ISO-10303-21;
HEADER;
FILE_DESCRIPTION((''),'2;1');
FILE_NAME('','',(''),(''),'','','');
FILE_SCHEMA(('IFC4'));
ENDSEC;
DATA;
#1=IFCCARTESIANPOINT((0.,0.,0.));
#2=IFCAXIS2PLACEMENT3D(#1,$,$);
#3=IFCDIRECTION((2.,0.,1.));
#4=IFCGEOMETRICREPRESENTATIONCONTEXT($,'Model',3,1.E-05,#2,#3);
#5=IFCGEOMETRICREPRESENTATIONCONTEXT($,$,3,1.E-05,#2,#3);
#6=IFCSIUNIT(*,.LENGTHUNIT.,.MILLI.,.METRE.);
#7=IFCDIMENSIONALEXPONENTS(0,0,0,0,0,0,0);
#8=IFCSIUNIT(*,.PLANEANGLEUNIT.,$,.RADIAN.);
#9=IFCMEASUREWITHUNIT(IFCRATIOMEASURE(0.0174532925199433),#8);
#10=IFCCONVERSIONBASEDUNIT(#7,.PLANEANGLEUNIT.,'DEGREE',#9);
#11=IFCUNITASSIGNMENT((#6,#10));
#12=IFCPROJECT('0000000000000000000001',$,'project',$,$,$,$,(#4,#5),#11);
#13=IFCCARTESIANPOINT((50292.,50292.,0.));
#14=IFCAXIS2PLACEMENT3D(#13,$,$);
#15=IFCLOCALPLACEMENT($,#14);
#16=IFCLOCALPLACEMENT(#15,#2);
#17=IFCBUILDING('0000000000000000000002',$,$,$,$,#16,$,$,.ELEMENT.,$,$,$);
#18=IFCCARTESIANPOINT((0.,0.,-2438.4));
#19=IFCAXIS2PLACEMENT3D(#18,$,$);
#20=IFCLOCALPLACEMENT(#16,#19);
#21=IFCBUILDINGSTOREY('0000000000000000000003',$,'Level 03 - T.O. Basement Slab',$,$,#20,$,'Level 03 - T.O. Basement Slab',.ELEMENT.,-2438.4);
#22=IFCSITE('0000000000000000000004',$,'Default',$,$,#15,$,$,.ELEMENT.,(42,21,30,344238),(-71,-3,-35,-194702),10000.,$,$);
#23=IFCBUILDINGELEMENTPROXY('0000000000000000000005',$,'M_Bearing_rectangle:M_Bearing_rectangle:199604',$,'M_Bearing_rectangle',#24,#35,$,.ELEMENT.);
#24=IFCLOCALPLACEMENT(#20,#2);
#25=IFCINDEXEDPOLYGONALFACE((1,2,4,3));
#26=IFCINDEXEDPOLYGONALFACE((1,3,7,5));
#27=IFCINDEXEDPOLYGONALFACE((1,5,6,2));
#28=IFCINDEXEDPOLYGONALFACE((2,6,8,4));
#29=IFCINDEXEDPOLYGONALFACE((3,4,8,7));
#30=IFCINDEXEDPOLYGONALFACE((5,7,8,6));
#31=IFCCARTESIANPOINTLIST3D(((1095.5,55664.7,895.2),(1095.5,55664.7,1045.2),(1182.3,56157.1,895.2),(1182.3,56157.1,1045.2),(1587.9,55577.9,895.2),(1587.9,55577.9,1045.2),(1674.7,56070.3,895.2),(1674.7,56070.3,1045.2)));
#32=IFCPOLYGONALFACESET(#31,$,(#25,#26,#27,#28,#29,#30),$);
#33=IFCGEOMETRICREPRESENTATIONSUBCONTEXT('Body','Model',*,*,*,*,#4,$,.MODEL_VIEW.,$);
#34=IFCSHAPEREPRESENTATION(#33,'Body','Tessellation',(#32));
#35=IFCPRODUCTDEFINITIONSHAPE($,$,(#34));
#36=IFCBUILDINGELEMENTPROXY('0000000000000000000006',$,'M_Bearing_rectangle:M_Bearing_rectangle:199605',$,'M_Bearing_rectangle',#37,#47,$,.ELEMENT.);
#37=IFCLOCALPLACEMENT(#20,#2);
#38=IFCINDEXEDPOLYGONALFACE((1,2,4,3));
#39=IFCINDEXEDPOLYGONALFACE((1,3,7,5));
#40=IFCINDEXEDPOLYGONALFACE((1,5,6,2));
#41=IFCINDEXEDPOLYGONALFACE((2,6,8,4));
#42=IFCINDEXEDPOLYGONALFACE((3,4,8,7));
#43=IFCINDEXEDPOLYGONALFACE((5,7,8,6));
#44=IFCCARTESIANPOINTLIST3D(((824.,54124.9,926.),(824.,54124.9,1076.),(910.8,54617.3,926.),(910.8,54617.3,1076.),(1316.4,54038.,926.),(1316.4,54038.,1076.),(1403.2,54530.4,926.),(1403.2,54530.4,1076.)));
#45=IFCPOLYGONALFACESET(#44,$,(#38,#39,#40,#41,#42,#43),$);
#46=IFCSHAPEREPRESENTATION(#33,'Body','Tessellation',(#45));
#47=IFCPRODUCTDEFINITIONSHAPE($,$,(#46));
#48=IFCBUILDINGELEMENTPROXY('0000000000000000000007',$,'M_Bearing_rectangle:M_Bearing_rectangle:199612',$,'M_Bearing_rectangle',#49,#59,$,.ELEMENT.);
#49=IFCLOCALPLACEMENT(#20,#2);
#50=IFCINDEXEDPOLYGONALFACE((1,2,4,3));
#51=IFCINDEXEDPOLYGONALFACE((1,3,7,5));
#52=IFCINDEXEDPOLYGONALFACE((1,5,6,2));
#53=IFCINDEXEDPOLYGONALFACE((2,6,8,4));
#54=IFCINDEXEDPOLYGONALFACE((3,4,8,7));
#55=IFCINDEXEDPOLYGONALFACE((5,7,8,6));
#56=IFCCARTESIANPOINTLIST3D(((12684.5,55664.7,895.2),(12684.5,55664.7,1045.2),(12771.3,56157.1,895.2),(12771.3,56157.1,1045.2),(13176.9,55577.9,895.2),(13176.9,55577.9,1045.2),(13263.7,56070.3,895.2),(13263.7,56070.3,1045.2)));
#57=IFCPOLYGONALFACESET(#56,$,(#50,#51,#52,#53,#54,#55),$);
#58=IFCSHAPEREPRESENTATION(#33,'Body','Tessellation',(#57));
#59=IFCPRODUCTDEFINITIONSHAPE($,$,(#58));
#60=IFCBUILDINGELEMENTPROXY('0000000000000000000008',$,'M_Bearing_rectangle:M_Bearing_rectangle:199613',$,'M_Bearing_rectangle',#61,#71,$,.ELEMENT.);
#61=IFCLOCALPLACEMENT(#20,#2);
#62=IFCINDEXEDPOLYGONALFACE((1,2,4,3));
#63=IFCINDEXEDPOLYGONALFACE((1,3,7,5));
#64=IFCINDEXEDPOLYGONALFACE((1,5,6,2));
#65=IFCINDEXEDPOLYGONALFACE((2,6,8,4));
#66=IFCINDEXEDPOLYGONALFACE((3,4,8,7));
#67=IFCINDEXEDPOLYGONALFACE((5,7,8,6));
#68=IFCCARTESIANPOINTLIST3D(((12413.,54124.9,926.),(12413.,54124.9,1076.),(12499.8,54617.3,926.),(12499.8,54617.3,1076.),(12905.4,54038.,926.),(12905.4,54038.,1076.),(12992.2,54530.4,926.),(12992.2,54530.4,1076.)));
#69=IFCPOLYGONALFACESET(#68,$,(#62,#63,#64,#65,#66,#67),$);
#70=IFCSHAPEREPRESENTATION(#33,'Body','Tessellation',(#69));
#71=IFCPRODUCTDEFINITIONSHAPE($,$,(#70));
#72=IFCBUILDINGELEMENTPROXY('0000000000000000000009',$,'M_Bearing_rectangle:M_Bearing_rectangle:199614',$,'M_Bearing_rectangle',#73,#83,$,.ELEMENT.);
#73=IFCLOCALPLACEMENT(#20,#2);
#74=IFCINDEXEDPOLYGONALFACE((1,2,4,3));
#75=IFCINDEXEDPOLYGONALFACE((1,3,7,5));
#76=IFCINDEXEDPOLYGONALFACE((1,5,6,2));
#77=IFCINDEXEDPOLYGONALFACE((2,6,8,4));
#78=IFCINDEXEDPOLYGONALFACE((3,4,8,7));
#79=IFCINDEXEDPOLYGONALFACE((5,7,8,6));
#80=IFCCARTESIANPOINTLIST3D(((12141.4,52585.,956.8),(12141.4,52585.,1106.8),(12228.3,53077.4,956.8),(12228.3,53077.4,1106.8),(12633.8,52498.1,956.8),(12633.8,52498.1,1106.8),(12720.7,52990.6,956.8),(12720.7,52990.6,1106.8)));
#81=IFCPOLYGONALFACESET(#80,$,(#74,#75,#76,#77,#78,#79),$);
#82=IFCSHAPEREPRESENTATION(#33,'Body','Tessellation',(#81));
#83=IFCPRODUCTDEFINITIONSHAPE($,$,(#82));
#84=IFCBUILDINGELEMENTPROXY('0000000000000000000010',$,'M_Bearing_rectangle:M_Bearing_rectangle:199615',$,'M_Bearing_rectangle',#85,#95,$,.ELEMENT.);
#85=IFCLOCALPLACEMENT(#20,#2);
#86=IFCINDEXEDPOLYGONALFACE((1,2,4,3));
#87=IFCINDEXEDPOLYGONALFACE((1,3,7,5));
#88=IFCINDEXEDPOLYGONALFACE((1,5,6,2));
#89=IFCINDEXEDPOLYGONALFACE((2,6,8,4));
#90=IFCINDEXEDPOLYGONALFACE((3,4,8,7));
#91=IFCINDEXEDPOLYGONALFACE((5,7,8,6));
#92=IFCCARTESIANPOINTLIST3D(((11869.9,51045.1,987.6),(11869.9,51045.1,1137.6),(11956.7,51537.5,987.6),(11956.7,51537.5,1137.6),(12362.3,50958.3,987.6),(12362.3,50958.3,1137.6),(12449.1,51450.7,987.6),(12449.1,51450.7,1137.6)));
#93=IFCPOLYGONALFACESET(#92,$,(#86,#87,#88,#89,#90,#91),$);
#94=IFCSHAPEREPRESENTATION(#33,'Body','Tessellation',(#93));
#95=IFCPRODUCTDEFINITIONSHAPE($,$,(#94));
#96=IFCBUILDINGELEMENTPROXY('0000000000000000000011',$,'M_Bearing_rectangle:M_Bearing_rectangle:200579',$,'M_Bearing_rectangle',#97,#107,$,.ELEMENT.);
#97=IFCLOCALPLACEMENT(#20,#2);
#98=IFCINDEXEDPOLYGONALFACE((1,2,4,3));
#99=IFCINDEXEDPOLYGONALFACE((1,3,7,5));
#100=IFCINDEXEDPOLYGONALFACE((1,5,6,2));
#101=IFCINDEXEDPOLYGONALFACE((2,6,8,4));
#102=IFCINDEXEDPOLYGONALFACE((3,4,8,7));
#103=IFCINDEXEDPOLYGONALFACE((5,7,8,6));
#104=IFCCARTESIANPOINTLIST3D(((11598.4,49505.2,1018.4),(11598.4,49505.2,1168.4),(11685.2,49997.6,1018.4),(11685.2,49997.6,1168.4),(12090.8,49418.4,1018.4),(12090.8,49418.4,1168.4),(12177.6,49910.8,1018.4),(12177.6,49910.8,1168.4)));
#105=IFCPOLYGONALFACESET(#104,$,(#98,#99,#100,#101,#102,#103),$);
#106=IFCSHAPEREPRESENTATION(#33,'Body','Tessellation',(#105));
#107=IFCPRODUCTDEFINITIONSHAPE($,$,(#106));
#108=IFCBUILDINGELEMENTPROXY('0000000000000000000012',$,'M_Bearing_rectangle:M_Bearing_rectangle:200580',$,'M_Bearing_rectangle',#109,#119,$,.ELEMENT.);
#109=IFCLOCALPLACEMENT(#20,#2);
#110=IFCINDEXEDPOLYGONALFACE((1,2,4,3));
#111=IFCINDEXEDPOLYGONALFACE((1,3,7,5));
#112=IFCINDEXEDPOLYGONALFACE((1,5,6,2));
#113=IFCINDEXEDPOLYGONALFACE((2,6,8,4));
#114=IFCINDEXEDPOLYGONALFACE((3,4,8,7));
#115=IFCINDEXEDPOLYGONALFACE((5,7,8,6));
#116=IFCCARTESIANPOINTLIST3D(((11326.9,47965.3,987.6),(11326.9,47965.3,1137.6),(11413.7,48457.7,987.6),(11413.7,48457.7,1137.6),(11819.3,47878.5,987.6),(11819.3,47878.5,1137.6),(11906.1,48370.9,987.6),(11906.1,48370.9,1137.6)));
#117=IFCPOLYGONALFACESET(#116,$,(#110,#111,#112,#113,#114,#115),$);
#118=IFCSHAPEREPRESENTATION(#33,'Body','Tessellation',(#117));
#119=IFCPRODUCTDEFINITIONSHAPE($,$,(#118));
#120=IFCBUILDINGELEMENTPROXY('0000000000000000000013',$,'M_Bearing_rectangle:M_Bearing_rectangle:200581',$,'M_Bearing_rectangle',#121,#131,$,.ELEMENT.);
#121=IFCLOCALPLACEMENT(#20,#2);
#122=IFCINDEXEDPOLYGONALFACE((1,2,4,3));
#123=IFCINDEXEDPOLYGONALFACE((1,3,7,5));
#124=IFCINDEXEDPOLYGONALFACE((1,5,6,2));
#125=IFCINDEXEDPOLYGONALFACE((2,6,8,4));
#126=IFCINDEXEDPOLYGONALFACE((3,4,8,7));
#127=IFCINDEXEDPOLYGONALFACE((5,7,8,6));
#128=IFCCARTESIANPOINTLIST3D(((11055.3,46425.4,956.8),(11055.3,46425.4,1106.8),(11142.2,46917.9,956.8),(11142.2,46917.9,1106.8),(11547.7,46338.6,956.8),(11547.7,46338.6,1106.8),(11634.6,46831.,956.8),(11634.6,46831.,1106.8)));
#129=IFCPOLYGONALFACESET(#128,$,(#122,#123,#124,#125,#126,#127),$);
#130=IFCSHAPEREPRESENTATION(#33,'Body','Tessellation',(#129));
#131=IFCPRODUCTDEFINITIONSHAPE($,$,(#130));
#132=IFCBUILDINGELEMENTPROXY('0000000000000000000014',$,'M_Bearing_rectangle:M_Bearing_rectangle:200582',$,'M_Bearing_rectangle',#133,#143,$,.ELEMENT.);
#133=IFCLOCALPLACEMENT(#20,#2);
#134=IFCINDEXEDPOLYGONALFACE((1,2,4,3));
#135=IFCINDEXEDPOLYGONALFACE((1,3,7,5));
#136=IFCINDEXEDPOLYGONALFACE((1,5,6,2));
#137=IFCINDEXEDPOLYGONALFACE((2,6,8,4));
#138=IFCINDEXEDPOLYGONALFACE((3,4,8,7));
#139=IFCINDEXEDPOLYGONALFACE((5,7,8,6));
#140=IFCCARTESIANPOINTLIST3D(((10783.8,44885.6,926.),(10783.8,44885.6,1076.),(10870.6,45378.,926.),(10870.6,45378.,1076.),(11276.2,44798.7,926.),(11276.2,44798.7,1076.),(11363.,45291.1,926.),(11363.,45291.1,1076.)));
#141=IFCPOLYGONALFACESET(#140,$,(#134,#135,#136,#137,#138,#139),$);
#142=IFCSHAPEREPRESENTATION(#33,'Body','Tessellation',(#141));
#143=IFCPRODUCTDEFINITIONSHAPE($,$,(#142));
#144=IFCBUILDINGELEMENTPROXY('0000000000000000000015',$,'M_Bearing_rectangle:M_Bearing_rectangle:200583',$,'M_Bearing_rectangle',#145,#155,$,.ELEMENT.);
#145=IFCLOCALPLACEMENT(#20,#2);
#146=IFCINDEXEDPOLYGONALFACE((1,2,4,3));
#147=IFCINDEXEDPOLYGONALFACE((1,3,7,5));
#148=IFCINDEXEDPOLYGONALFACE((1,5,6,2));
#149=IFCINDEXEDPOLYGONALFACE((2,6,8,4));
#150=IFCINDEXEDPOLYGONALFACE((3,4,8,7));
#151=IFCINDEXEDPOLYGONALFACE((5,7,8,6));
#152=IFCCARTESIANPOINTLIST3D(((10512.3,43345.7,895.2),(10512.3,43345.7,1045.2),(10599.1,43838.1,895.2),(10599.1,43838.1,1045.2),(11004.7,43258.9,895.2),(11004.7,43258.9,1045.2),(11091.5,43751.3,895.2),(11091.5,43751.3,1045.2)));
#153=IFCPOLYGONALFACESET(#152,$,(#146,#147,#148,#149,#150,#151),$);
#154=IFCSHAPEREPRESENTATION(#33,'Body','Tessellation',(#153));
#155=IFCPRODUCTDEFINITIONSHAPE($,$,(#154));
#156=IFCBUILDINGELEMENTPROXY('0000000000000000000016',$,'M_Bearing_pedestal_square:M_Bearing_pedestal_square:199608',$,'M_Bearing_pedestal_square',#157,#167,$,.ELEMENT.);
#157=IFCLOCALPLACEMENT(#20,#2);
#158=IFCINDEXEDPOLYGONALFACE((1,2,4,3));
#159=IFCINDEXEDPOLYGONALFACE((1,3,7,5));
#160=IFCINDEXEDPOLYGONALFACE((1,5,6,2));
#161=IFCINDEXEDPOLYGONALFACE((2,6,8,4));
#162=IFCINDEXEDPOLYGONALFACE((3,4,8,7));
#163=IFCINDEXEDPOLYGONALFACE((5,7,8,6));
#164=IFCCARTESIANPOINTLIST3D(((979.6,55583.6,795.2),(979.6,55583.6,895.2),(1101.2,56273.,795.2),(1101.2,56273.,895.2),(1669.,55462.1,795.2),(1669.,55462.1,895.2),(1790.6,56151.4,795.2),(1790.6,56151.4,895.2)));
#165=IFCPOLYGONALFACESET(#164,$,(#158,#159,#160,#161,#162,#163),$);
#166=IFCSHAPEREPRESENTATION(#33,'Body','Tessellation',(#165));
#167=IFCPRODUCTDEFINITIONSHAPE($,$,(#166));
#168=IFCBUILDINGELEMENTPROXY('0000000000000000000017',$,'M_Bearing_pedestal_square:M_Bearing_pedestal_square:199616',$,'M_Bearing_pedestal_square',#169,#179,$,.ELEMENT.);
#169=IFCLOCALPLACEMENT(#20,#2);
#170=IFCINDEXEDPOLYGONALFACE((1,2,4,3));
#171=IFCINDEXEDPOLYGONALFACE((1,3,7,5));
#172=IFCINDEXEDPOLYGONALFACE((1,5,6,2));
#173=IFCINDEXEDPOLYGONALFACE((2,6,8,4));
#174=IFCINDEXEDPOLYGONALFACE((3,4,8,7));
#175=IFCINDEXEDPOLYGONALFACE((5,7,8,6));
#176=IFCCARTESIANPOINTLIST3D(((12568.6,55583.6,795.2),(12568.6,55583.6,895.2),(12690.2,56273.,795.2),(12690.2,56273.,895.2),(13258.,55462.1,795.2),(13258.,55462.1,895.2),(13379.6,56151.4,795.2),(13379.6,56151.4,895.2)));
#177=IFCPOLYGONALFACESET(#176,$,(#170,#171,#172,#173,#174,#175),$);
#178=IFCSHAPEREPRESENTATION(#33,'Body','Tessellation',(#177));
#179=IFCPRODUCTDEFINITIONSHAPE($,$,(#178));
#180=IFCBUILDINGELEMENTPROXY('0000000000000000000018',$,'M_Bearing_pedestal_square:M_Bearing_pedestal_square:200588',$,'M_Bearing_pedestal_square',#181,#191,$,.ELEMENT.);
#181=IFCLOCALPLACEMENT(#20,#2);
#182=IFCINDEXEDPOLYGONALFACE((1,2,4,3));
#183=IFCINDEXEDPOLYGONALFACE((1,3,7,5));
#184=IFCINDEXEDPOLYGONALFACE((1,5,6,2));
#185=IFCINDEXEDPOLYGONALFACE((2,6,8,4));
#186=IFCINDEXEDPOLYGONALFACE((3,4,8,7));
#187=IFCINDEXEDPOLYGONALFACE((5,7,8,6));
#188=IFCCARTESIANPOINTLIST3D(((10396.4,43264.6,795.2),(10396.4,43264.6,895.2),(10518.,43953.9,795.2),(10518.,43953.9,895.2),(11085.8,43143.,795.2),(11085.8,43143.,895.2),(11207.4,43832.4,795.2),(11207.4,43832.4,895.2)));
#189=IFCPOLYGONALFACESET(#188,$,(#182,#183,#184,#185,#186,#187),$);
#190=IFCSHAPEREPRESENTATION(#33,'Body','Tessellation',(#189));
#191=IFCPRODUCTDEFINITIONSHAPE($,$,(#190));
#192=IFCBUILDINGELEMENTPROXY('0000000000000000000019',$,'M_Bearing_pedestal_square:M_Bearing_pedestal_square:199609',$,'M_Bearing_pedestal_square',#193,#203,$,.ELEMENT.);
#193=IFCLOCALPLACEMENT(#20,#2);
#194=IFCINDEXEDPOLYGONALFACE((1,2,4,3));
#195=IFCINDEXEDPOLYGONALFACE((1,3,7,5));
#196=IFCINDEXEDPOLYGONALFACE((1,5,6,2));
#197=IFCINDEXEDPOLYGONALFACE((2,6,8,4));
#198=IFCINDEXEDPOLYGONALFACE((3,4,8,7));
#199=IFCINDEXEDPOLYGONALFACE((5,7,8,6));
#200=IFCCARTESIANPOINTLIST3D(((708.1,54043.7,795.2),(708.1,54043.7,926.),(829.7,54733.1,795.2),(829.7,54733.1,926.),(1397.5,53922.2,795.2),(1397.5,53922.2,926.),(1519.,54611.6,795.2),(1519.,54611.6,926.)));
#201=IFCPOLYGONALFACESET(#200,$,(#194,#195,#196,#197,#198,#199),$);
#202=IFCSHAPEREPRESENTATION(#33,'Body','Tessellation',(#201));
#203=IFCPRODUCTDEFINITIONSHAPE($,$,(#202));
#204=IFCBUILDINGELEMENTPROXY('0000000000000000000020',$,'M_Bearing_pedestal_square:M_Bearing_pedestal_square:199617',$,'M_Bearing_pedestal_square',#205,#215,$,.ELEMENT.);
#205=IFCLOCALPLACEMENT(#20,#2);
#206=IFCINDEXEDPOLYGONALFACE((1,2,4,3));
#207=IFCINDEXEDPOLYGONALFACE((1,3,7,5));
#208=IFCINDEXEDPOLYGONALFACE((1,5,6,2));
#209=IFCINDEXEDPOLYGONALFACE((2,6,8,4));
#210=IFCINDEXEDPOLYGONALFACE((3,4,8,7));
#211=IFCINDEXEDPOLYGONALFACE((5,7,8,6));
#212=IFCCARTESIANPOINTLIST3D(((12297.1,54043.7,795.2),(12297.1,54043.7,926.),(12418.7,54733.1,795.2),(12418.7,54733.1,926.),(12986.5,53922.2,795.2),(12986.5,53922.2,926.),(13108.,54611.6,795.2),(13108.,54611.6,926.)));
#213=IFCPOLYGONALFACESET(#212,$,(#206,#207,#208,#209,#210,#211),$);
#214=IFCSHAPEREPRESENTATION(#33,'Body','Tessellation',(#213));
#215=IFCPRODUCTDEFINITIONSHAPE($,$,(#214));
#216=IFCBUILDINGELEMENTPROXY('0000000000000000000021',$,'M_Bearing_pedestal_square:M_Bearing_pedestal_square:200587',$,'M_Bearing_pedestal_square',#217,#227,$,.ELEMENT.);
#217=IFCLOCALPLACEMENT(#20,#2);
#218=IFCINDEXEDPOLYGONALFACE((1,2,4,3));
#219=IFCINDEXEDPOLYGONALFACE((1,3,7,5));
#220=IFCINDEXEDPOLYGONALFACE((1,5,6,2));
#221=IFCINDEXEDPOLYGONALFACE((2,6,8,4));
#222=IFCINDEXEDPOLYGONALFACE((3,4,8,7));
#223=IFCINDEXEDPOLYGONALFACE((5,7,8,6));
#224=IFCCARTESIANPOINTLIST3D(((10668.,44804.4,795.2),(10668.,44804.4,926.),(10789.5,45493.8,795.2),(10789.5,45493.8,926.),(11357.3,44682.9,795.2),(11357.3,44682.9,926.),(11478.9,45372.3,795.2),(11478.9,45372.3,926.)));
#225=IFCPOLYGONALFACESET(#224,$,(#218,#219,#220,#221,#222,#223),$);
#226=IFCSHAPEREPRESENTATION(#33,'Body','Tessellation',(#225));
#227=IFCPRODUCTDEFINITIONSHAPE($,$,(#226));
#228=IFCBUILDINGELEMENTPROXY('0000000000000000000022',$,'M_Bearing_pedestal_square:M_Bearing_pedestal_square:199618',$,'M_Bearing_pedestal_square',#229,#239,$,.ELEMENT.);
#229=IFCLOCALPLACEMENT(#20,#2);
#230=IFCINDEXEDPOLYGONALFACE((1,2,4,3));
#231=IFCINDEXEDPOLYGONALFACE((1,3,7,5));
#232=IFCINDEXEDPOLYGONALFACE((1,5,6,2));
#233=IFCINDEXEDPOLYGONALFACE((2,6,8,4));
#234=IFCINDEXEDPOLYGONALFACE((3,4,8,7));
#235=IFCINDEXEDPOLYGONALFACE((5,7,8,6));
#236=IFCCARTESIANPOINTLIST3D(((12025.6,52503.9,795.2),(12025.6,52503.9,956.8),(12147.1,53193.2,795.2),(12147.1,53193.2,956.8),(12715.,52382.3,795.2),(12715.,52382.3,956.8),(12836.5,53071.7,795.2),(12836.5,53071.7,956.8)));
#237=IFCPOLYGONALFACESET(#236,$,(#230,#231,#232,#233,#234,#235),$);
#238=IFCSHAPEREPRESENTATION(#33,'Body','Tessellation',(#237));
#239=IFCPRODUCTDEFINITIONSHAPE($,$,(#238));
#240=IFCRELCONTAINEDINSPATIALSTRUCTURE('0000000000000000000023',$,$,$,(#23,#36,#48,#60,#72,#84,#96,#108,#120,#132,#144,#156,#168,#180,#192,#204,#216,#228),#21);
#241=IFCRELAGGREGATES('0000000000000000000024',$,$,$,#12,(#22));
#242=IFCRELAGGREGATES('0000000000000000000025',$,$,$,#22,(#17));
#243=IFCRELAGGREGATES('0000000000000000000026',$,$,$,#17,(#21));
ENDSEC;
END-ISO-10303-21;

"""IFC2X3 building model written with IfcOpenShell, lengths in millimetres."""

from ifc_helpers import new_model, entity, si_unit, converted_unit, direction, frame, origin, origin_2d_with_axis, place, context, subcontext, project, spatial, rectangle, extrude, source, transform, mapped, element, save


model = new_model("IFC2X3")

# Units and contexts
model_context = context("Model", 3, precision=1e-05, world=origin(), true_north=direction((2.0, 0.0, 1.0)))
context_of_model = context(None, 3, precision=1e-05, world=origin(), true_north=direction((2.0, 0.0, 1.0)))
body_context = subcontext(model_context, "Body", "Model", "MODEL_VIEW")
ifc_project = project(units=[si_unit("LENGTHUNIT", "METRE", prefix="MILLI"), converted_unit("PLANEANGLEUNIT", "DEGREE", entity("IfcRatioMeasure", 0.0174532925199433), si_unit("PLANEANGLEUNIT", "RADIAN"), dimensions=[0, 0, 0, 0, 0, 0, 0])], contexts=[model_context, context_of_model])

# Site, building, storey
site_placement = place(None, frame((50292.0, 50292.0, 0.0)))
site = spatial("IfcSite", under=ifc_project, at=site_placement, Name="Default", CompositionType="ELEMENT", RefLatitude=(42, 21, 30, 344238), RefLongitude=(-71, -3, -35, -194702), RefElevation=10000.0)
building_placement = place(site_placement, origin())
building = spatial("IfcBuilding", under=site, at=building_placement, CompositionType="ELEMENT")
storey_placement = place(building_placement, frame((0.0, 0.0, -2438.4)))
storey = spatial("IfcBuildingStorey", under=building, at=storey_placement, Name="Level 03 - T.O. Basement Slab", LongName="Level 03 - T.O. Basement Slab", CompositionType="ELEMENT", Elevation=-2438.4)

# Building element proxies
shared_shape_1 = source(origin(), body_context, "Body", "SweptSolid", [
    extrude(rectangle(XDim=500.0, YDim=500.0, at=origin_2d_with_axis()), frame((0.0, 0.0, -150.0), z_axis=(0.0, 0.0, 1.0), x_axis=(-1.0, 0.0, 0.0)), (0.0, 0.0, 1.0), 150.0),
])
for number, where, z_axis, x_axis, name in (
    (1, (1385.1, 55867.5, 1045.2), (0.0, 0.0, 1.0), (0.173648, 0.984808, 0.0), "M_Bearing_rectangle:M_Bearing_rectangle:199604"),
    (2, (1113.6, 54327.6, 1076.0), (0.0, 0.0, 1.0), (0.173648, 0.984808, 0.0), "M_Bearing_rectangle:M_Bearing_rectangle:199605"),
    (3, (12974.1, 55867.5, 1045.2), (0.0, 0.0, 1.0), (0.173648, 0.984808, 0.0), "M_Bearing_rectangle:M_Bearing_rectangle:199612"),
    (4, (12702.6, 54327.6, 1076.0), (0.0, 0.0, 1.0), (0.173648, 0.984808, 0.0), "M_Bearing_rectangle:M_Bearing_rectangle:199613"),
    (5, (12431.0, 52787.8, 1106.8), (0.0, 0.0, 1.0), (0.173648, 0.984808, 0.0), "M_Bearing_rectangle:M_Bearing_rectangle:199614"),
    (6, (12159.5, 51247.9, 1137.6), (0.0, 0.0, 1.0), (0.173648, 0.984808, 0.0), "M_Bearing_rectangle:M_Bearing_rectangle:199615"),
    (7, (11888.0, 49708.0, 1168.4), (0.0, 0.0, 1.0), (0.173648, 0.984808, 0.0), "M_Bearing_rectangle:M_Bearing_rectangle:200579"),
    (8, (11616.5, 48168.1, 1137.6), (0.0, 0.0, 1.0), (0.173648, 0.984808, 0.0), "M_Bearing_rectangle:M_Bearing_rectangle:200580"),
    (9, (11345.0, 46628.2, 1106.8), (0.0, 0.0, 1.0), (0.173648, 0.984808, 0.0), "M_Bearing_rectangle:M_Bearing_rectangle:200581"),
    (10, (11073.4, 45088.4, 1076.0), (0.0, 0.0, 1.0), (0.173648, 0.984808, 0.0), "M_Bearing_rectangle:M_Bearing_rectangle:200582"),
    (11, (10801.9, 43548.5, 1045.2), (0.0, 0.0, 1.0), (0.173648, 0.984808, 0.0), "M_Bearing_rectangle:M_Bearing_rectangle:200583"),
):
    element("IfcBuildingElementProxy", number, at=place(storey_placement, frame(where, z_axis=z_axis, x_axis=x_axis)), inside=storey, Name=name, ObjectType="M_Bearing_rectangle", CompositionType="ELEMENT", context=body_context, shape_type="MappedRepresentation", body=[
        mapped(shared_shape_1, transform((0.0, 0.0, 0.0), scale=1.0)),
    ])
shared_shape_2 = source(origin(), body_context, "Body", "SweptSolid", [
    extrude(rectangle(XDim=700.0, YDim=700.0, at=origin_2d_with_axis()), frame((0.0, 0.0, -100.0)), (0.0, 0.0, 1.0), 100.0),
])
for number, where, z_axis, x_axis, name in (
    (12, (1385.1, 55867.5, 895.2), (0.0, 0.0, 1.0), (0.173648, 0.984808, 0.0), "M_Bearing_pedestal_square:M_Bearing_pedestal_square:199608"),
    (13, (12974.1, 55867.5, 895.2), (0.0, 0.0, 1.0), (0.173648, 0.984808, 0.0), "M_Bearing_pedestal_square:M_Bearing_pedestal_square:199616"),
    (14, (10801.9, 43548.5, 895.2), (0.0, 0.0, 1.0), (0.173648, 0.984808, 0.0), "M_Bearing_pedestal_square:M_Bearing_pedestal_square:200588"),
):
    element("IfcBuildingElementProxy", number, at=place(storey_placement, frame(where, z_axis=z_axis, x_axis=x_axis)), inside=storey, Name=name, ObjectType="M_Bearing_pedestal_square", CompositionType="ELEMENT", context=body_context, shape_type="MappedRepresentation", body=[
        mapped(shared_shape_2, transform((0.0, 0.0, 0.0), scale=1.0)),
    ])
shared_shape_3 = source(origin(), body_context, "Body", "SweptSolid", [
    extrude(rectangle(XDim=700.0, YDim=700.0, at=origin_2d_with_axis()), frame((0.0, 0.0, -130.8)), (0.0, 0.0, 1.0), 130.8),
])
for number, where, z_axis, x_axis, name in (
    (15, (1113.6, 54327.6, 926.0), (0.0, 0.0, 1.0), (0.173648, 0.984808, 0.0), "M_Bearing_pedestal_square:M_Bearing_pedestal_square:199609"),
    (16, (12702.6, 54327.6, 926.0), (0.0, 0.0, 1.0), (0.173648, 0.984808, 0.0), "M_Bearing_pedestal_square:M_Bearing_pedestal_square:199617"),
    (17, (11073.4, 45088.4, 926.0), (0.0, 0.0, 1.0), (0.173648, 0.984808, 0.0), "M_Bearing_pedestal_square:M_Bearing_pedestal_square:200587"),
):
    element("IfcBuildingElementProxy", number, at=place(storey_placement, frame(where, z_axis=z_axis, x_axis=x_axis)), inside=storey, Name=name, ObjectType="M_Bearing_pedestal_square", CompositionType="ELEMENT", context=body_context, shape_type="MappedRepresentation", body=[
        mapped(shared_shape_3, transform((0.0, 0.0, 0.0), scale=1.0)),
    ])
shared_shape_4 = source(origin(), body_context, "Body", "SweptSolid", [
    extrude(rectangle(XDim=700.0, YDim=700.0, at=origin_2d_with_axis()), frame((0.0, 0.0, -161.6)), (0.0, 0.0, 1.0), 161.6),
])
for number, where, z_axis, x_axis, name in (
    (18, (12431.0, 52787.8, 956.8), (0.0, 0.0, 1.0), (0.173648, 0.984808, 0.0), "M_Bearing_pedestal_square:M_Bearing_pedestal_square:199618"),
):
    element("IfcBuildingElementProxy", number, at=place(storey_placement, frame(where, z_axis=z_axis, x_axis=x_axis)), inside=storey, Name=name, ObjectType="M_Bearing_pedestal_square", CompositionType="ELEMENT", context=body_context, shape_type="MappedRepresentation", body=[
        mapped(shared_shape_4, transform((0.0, 0.0, 0.0), scale=1.0)),
    ])

save(model, "model.ifc")
